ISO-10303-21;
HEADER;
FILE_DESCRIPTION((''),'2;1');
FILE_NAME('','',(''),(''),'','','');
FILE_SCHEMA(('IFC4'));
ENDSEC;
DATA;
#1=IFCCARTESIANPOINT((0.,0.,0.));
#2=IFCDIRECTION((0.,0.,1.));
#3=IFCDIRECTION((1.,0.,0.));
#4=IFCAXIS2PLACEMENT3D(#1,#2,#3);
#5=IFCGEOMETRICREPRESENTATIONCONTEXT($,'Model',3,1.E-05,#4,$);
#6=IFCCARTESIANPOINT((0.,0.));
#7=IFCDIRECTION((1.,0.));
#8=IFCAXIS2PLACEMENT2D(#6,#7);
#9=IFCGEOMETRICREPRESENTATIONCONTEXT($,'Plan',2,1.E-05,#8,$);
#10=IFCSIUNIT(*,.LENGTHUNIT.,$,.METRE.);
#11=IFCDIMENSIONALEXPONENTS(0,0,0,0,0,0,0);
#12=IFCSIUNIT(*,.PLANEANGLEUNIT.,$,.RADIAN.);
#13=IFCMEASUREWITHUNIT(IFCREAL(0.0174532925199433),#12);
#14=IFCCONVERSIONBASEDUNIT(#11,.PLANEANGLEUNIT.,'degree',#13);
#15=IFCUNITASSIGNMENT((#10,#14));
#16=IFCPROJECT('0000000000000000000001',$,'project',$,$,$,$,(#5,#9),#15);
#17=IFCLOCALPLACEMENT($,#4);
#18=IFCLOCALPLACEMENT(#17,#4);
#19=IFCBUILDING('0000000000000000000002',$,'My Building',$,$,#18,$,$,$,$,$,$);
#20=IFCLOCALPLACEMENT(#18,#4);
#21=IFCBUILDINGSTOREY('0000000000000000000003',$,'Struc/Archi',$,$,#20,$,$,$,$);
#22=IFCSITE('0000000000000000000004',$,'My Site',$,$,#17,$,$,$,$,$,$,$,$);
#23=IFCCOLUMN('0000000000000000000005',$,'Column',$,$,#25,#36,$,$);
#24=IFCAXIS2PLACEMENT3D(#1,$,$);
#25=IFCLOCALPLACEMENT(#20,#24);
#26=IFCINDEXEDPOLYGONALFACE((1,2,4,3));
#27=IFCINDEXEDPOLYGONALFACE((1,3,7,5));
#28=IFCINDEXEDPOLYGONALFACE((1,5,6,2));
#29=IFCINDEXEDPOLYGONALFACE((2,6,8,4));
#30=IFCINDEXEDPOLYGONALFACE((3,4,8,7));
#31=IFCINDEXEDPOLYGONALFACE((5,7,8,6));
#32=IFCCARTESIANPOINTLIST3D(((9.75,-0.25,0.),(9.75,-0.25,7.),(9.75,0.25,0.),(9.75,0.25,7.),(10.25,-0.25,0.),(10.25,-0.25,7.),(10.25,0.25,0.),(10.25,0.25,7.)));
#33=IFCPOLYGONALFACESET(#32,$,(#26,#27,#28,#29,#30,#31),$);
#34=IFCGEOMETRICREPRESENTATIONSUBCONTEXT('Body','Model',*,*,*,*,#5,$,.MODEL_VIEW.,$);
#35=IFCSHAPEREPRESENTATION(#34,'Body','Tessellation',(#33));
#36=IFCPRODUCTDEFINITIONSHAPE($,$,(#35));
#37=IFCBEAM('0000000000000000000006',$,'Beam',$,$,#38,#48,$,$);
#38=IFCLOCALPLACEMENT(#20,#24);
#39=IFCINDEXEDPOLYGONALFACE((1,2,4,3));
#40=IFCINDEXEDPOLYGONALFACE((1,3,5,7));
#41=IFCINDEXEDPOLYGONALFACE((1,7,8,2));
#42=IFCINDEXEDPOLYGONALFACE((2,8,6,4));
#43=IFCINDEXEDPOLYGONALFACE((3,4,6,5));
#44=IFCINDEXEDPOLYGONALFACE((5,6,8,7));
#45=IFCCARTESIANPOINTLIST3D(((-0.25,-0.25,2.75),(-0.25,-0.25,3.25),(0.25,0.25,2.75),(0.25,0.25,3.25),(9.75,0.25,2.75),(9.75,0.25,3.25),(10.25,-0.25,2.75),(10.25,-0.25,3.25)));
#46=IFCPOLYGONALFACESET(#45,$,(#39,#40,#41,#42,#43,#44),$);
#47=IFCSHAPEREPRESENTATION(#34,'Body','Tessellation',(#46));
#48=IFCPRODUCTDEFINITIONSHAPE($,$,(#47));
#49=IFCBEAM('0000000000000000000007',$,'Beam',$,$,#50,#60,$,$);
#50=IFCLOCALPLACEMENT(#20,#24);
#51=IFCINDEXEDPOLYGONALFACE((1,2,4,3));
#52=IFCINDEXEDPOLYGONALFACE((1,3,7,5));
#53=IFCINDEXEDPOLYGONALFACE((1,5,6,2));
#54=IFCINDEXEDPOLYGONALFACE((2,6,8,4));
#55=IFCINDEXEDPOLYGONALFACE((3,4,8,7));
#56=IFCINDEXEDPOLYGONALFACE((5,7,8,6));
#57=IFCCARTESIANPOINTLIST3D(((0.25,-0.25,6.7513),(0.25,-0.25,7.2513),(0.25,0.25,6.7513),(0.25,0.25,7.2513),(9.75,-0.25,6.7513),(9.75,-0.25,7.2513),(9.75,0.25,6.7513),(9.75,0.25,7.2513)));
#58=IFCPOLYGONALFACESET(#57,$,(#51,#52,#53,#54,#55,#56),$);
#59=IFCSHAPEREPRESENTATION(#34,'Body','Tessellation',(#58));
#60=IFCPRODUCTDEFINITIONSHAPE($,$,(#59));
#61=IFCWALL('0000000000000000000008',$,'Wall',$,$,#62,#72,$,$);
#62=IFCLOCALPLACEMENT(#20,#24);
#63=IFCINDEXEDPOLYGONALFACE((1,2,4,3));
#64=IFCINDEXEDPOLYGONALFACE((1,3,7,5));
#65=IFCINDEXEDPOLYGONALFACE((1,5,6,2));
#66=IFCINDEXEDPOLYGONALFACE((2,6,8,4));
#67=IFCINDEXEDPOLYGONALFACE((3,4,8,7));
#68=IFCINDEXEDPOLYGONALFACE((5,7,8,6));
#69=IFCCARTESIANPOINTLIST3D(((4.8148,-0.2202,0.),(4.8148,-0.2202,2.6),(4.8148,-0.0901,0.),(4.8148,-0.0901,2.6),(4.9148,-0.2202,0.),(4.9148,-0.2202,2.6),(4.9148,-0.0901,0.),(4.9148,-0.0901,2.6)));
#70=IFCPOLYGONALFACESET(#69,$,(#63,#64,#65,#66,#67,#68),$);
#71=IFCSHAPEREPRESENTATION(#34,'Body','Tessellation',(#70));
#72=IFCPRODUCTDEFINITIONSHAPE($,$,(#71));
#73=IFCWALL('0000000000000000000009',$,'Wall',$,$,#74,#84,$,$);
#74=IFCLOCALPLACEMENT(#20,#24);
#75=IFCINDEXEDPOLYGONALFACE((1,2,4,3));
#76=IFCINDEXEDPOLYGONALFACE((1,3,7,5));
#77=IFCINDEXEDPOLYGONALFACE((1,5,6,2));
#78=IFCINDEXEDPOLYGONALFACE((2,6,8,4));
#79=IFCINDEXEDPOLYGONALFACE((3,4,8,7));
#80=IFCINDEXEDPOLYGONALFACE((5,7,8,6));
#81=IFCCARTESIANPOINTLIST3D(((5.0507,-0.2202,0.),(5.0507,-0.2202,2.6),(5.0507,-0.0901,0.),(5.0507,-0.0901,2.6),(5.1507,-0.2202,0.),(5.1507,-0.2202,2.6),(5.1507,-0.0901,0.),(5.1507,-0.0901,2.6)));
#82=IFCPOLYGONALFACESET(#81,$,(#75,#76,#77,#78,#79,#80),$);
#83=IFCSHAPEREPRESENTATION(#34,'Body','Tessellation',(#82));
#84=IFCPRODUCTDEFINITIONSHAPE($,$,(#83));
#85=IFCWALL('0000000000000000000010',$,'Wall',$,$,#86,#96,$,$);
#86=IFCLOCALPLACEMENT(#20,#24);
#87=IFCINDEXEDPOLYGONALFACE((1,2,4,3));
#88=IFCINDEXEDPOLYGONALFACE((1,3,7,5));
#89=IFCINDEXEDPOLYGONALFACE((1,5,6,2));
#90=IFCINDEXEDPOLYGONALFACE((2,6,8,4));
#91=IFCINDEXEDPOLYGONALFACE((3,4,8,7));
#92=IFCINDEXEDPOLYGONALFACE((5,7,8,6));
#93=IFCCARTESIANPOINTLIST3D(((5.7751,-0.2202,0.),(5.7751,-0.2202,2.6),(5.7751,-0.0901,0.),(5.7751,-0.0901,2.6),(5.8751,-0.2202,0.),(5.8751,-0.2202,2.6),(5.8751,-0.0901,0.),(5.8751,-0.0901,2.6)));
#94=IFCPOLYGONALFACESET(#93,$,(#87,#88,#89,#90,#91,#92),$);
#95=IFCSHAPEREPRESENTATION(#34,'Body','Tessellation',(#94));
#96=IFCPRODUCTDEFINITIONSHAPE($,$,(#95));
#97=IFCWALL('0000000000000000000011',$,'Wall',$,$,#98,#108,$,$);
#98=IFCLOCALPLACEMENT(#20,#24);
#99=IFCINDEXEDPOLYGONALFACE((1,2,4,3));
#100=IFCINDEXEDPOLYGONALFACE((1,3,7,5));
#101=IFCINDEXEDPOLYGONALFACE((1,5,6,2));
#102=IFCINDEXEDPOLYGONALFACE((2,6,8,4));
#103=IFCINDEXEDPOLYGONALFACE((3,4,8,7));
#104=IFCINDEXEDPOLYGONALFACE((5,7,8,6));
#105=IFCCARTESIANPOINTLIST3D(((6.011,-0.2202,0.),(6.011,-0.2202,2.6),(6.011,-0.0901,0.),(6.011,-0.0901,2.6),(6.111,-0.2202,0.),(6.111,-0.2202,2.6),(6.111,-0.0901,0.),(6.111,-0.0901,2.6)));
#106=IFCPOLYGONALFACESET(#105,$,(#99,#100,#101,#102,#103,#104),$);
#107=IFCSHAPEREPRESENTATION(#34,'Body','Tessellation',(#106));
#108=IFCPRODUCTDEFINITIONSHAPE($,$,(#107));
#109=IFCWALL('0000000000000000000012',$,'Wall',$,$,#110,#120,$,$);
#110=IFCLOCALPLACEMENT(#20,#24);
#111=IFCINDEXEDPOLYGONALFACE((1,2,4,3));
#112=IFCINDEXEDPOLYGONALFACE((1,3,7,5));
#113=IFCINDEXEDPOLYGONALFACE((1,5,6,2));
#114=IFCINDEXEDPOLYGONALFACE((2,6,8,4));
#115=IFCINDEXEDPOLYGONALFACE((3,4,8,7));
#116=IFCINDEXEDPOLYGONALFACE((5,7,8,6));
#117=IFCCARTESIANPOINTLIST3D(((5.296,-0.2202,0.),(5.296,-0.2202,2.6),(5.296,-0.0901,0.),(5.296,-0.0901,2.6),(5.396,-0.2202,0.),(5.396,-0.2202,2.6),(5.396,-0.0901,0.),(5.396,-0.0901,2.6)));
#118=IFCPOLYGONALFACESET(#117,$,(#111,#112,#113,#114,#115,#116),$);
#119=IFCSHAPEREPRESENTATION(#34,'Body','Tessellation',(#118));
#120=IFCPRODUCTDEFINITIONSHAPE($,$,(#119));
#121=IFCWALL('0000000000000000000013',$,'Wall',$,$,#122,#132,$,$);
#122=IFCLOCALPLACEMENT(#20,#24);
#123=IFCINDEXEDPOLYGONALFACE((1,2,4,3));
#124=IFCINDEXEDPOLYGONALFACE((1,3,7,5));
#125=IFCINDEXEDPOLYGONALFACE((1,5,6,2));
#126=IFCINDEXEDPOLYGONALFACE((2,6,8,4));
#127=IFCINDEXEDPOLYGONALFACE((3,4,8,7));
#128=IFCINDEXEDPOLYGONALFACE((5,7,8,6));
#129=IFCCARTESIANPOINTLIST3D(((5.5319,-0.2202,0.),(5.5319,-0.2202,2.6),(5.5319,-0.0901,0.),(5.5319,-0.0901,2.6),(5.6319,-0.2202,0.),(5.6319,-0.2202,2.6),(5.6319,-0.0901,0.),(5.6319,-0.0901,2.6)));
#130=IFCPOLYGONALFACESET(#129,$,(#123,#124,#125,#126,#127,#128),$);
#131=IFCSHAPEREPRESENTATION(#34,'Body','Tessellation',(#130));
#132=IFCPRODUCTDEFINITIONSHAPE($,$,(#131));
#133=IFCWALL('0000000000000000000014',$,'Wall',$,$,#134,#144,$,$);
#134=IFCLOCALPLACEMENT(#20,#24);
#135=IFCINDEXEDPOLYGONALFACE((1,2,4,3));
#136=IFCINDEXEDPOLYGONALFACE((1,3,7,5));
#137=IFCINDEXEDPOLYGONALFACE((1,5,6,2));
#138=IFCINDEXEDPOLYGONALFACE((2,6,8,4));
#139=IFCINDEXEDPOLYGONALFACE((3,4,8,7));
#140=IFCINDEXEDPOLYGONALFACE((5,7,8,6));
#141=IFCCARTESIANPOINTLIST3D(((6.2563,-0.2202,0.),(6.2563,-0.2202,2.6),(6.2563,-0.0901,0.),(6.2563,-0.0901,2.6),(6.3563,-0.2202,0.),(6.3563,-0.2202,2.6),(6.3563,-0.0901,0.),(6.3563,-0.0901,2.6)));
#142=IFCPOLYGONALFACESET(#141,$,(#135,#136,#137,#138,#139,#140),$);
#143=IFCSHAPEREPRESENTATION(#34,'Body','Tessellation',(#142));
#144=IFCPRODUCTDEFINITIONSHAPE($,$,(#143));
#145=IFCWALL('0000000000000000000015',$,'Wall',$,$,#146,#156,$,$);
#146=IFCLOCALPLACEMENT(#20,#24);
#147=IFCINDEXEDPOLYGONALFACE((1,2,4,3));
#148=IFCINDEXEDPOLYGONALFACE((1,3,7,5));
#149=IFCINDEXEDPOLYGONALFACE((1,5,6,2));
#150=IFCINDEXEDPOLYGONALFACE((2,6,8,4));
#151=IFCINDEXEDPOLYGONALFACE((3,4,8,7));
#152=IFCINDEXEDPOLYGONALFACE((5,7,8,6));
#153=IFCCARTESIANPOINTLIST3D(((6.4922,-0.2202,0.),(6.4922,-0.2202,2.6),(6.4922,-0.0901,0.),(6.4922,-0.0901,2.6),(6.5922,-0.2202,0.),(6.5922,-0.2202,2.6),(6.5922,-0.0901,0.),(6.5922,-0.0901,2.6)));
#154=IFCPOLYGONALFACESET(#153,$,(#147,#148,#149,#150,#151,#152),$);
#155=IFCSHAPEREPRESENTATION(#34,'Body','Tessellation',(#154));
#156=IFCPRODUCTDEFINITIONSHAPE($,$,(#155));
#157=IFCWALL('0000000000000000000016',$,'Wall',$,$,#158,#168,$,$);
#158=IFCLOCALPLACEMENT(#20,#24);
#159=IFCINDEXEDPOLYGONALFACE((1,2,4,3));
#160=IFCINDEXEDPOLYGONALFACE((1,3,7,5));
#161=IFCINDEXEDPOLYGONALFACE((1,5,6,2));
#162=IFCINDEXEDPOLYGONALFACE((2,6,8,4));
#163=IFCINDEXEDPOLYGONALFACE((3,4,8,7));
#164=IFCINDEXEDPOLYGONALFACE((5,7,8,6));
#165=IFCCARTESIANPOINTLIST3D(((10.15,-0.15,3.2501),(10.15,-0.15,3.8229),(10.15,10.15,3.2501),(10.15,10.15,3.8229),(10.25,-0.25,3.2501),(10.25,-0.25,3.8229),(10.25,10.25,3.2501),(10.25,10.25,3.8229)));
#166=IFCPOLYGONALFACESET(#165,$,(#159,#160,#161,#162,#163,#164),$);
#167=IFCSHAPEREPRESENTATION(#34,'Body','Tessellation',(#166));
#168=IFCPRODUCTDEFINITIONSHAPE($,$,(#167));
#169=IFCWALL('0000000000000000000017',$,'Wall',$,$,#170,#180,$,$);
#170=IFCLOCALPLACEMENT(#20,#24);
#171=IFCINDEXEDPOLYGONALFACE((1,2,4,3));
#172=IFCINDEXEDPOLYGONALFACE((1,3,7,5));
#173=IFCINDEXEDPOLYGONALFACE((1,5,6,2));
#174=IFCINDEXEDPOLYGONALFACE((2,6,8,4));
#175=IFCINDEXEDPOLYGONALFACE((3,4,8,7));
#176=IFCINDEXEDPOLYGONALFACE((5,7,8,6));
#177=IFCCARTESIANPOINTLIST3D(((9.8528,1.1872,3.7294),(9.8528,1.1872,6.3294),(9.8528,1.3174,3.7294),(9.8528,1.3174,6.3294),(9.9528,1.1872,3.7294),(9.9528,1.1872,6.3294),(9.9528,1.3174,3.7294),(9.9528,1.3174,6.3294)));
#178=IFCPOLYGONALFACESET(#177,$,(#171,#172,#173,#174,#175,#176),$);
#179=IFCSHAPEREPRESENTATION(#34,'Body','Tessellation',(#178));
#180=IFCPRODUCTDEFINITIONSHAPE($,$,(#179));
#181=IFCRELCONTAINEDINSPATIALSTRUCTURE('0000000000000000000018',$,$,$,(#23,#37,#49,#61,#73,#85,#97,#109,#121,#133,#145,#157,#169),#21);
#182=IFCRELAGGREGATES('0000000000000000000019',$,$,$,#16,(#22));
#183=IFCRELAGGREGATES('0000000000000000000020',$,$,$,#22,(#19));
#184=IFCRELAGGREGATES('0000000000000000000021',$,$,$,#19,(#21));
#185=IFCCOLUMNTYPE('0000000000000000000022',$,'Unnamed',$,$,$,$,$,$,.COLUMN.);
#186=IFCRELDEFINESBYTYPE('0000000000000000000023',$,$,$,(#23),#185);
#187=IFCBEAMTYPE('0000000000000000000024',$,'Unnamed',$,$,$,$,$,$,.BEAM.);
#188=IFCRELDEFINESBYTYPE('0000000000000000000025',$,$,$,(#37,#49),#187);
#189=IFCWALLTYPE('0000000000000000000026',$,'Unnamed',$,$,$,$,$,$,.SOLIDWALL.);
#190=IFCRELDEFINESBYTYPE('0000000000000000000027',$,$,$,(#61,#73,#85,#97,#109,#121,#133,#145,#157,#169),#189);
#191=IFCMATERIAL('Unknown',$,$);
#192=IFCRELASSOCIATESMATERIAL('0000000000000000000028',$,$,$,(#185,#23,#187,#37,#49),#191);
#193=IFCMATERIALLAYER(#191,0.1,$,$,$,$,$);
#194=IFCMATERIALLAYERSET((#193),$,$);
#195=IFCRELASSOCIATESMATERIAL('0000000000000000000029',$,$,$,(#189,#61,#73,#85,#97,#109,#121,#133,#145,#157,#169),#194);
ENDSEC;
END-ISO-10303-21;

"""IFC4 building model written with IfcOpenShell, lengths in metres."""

from ifc_helpers import new_model, entity, si_unit, converted_unit, frame, origin_with_axes, origin_2d_with_axis, place, context, subcontext, project, spatial, line, indexed_curve, rectangle, outline, extrude, clip, halfspace, material, layer, layer_set, layer_usage, material_profile, profile_set, profile_usage, type_object, element, save


model = new_model("IFC4")

# Units and contexts
model_context = context("Model", 3, precision=1e-05, world=origin_with_axes())
plan_context = context("Plan", 2, precision=1e-05, world=origin_2d_with_axis())
body_context_1 = subcontext(model_context, "Body", "Model", "MODEL_VIEW")
ifc_project = project(units=[si_unit("LENGTHUNIT", "METRE"), converted_unit("PLANEANGLEUNIT", "degree", entity("IfcReal", 0.0174532925199433), si_unit("PLANEANGLEUNIT", "RADIAN"), dimensions=[0, 0, 0, 0, 0, 0, 0])], contexts=[model_context, plan_context])

# Site, building, storey
site_placement = place(None, origin_with_axes())
site = spatial("IfcSite", under=ifc_project, at=site_placement, Name="My Site")
building_placement = place(site_placement, origin_with_axes())
building = spatial("IfcBuilding", under=site, at=building_placement, Name="My Building")
storey_placement = place(building_placement, origin_with_axes())
storey = spatial("IfcBuildingStorey", under=building, at=storey_placement, Name="Struc/Archi")

# Column
ifc_material = material(Name="Unknown")
ifc_material_profile_1 = material_profile(ifc_material, rectangle(XDim=0.5, YDim=0.5))
ifc_profile_set_1 = profile_set([ifc_material_profile_1])
ifc_profile_usage_1 = profile_usage(ifc_profile_set_1, cardinal=5)
column_type = type_object("IfcColumnType", Name="Unnamed", PredefinedType="COLUMN", material=ifc_profile_set_1)
column_placement = place(storey_placement, frame((10.0, 0.0, 0.0), z_axis=(0.0, 0.0, 1.0), x_axis=(1.0, 0.0, 0.0)))
element("IfcColumn", 1, at=column_placement, inside=storey, type_object=column_type, material=ifc_profile_usage_1, Name="Column", context=body_context_1, shape_type="SweptSolid", body=[
    extrude(rectangle(XDim=0.5, YDim=0.5), origin_with_axes(), (0.0, 0.0, 1.0), 7.0),
])

# Beams
ifc_material_profile_2 = material_profile(ifc_material, rectangle(XDim=0.5, YDim=0.5))
ifc_profile_set_2 = profile_set([ifc_material_profile_2])
ifc_profile_usage_2 = profile_usage(ifc_profile_set_2, cardinal=5)
beam_type = type_object("IfcBeamType", Name="Unnamed", PredefinedType="BEAM", material=ifc_profile_set_2)
beam_1_placement = place(storey_placement, frame((10.25, 0.0, 3.0), z_axis=(-1.0, 0.0, 0.0), x_axis=(0.0, -1.0, 0.0)))
element("IfcBeam", 2, at=beam_1_placement, inside=storey, type_object=beam_type, material=ifc_profile_usage_2, Name="Beam", context=body_context_1, shape_type="Clipping", body=[
    clip(clip(extrude(rectangle(XDim=0.5, YDim=0.5), origin_with_axes(), (0.0, 0.0, 1.0), 10.5), halfspace(frame((0.25, -3.0, 10.5), z_axis=(-0.707107, 0.0, 0.707107), x_axis=(0.0, 1.0, 0.0)), False)), halfspace(frame((0.25, -3.0, 0.0), z_axis=(-0.707107, 0.0, -0.707107), x_axis=(0.0, 1.0, 0.0)), False)),
])
ifc_profile_usage_3 = profile_usage(ifc_profile_set_2, cardinal=5)
beam_2_placement = place(storey_placement, frame((9.75, 0.0, 7.0013), z_axis=(-1.0, 0.0, 0.0), x_axis=(0.0, -1.0, 0.0)))
element("IfcBeam", 3, at=beam_2_placement, inside=storey, type_object=beam_type, material=ifc_profile_usage_3, Name="Beam", context=body_context_1, shape_type="SweptSolid", body=[
    extrude(rectangle(XDim=0.5, YDim=0.5), origin_with_axes(), (0.0, 0.0, 1.0), 9.5),
])

# Shared definitions
ifc_layer = layer(ifc_material, 0.1)
ifc_layer_set = layer_set([ifc_layer])
wall_type = type_object("IfcWallType", Name="Unnamed", PredefinedType="SOLIDWALL", material=ifc_layer_set)

# Walls
ifc_layer_usage_1 = layer_usage(ifc_layer_set, "AXIS2", "POSITIVE", 0.0)
wall_1_placement = place(storey_placement, frame((4.8148, -0.0901, 0.0), z_axis=(0.0, 0.0, 1.0), x_axis=(0.0, -1.0, 0.0)))
element("IfcWall", 4, at=wall_1_placement, inside=storey, type_object=wall_type, material=ifc_layer_usage_1, Name="Wall", context=body_context_1, shape_type="SweptSolid", body=[
    extrude(outline(indexed_curve([(0.0, 0.0), (0.0, 0.1), (0.1301, 0.1), (0.1301, 0.0)], segments=[line(1, 2, 3, 4, 1)])), origin_with_axes(), (0.0, 0.0, 1.0), 2.6),
])
ifc_layer_usage_2 = layer_usage(ifc_layer_set, "AXIS2", "POSITIVE", 0.0)
wall_2_placement = place(storey_placement, frame((5.0507, -0.0901, 0.0), z_axis=(0.0, 0.0, 1.0), x_axis=(0.0, -1.0, 0.0)))
element("IfcWall", 5, at=wall_2_placement, inside=storey, type_object=wall_type, material=ifc_layer_usage_2, Name="Wall", context=body_context_1, shape_type="SweptSolid", body=[
    extrude(outline(indexed_curve([(0.0, 0.0), (0.0, 0.1), (0.1301, 0.1), (0.1301, 0.0)], segments=[line(1, 2, 3, 4, 1)])), origin_with_axes(), (0.0, 0.0, 1.0), 2.6),
])
ifc_layer_usage_3 = layer_usage(ifc_layer_set, "AXIS2", "POSITIVE", 0.0)
wall_3_placement = place(storey_placement, frame((5.7751, -0.0901, 0.0), z_axis=(0.0, 0.0, 1.0), x_axis=(0.0, -1.0, 0.0)))
element("IfcWall", 6, at=wall_3_placement, inside=storey, type_object=wall_type, material=ifc_layer_usage_3, Name="Wall", context=body_context_1, shape_type="SweptSolid", body=[
    extrude(outline(indexed_curve([(0.0, 0.0), (0.0, 0.1), (0.1301, 0.1), (0.1301, 0.0)], segments=[line(1, 2, 3, 4, 1)])), origin_with_axes(), (0.0, 0.0, 1.0), 2.6),
])
ifc_layer_usage_4 = layer_usage(ifc_layer_set, "AXIS2", "POSITIVE", 0.0)
wall_4_placement = place(storey_placement, frame((6.011, -0.0901, 0.0), z_axis=(0.0, 0.0, 1.0), x_axis=(0.0, -1.0, 0.0)))
element("IfcWall", 7, at=wall_4_placement, inside=storey, type_object=wall_type, material=ifc_layer_usage_4, Name="Wall", context=body_context_1, shape_type="SweptSolid", body=[
    extrude(outline(indexed_curve([(0.0, 0.0), (0.0, 0.1), (0.1301, 0.1), (0.1301, 0.0)], segments=[line(1, 2, 3, 4, 1)])), origin_with_axes(), (0.0, 0.0, 1.0), 2.6),
])
ifc_layer_usage_5 = layer_usage(ifc_layer_set, "AXIS2", "POSITIVE", 0.0)
wall_5_placement = place(storey_placement, frame((5.296, -0.0901, 0.0), z_axis=(0.0, 0.0, 1.0), x_axis=(0.0, -1.0, 0.0)))
element("IfcWall", 8, at=wall_5_placement, inside=storey, type_object=wall_type, material=ifc_layer_usage_5, Name="Wall", context=body_context_1, shape_type="SweptSolid", body=[
    extrude(outline(indexed_curve([(0.0, 0.0), (0.0, 0.1), (0.1301, 0.1), (0.1301, 0.0)], segments=[line(1, 2, 3, 4, 1)])), origin_with_axes(), (0.0, 0.0, 1.0), 2.6),
])
ifc_layer_usage_6 = layer_usage(ifc_layer_set, "AXIS2", "POSITIVE", 0.0)
wall_6_placement = place(storey_placement, frame((5.5319, -0.0901, 0.0), z_axis=(0.0, 0.0, 1.0), x_axis=(0.0, -1.0, 0.0)))
element("IfcWall", 9, at=wall_6_placement, inside=storey, type_object=wall_type, material=ifc_layer_usage_6, Name="Wall", context=body_context_1, shape_type="SweptSolid", body=[
    extrude(outline(indexed_curve([(0.0, 0.0), (0.0, 0.1), (0.1301, 0.1), (0.1301, 0.0)], segments=[line(1, 2, 3, 4, 1)])), origin_with_axes(), (0.0, 0.0, 1.0), 2.6),
])
ifc_layer_usage_7 = layer_usage(ifc_layer_set, "AXIS2", "POSITIVE", 0.0)
wall_7_placement = place(storey_placement, frame((6.2563, -0.0901, 0.0), z_axis=(0.0, 0.0, 1.0), x_axis=(0.0, -1.0, 0.0)))
element("IfcWall", 10, at=wall_7_placement, inside=storey, type_object=wall_type, material=ifc_layer_usage_7, Name="Wall", context=body_context_1, shape_type="SweptSolid", body=[
    extrude(outline(indexed_curve([(0.0, 0.0), (0.0, 0.1), (0.1301, 0.1), (0.1301, 0.0)], segments=[line(1, 2, 3, 4, 1)])), origin_with_axes(), (0.0, 0.0, 1.0), 2.6),
])
ifc_layer_usage_8 = layer_usage(ifc_layer_set, "AXIS2", "POSITIVE", 0.0)
wall_8_placement = place(storey_placement, frame((6.4922, -0.0901, 0.0), z_axis=(0.0, 0.0, 1.0), x_axis=(0.0, -1.0, 0.0)))
element("IfcWall", 11, at=wall_8_placement, inside=storey, type_object=wall_type, material=ifc_layer_usage_8, Name="Wall", context=body_context_1, shape_type="SweptSolid", body=[
    extrude(outline(indexed_curve([(0.0, 0.0), (0.0, 0.1), (0.1301, 0.1), (0.1301, 0.0)], segments=[line(1, 2, 3, 4, 1)])), origin_with_axes(), (0.0, 0.0, 1.0), 2.6),
])
ifc_layer_usage_9 = layer_usage(ifc_layer_set, "AXIS2", "POSITIVE", 0.0)
wall_9_placement = place(storey_placement, frame((10.25, -0.25, 3.2501), z_axis=(0.0, 0.0, 1.0), x_axis=(0.0, 1.0, 0.0)))
element("IfcWall", 12, at=wall_9_placement, inside=storey, type_object=wall_type, material=ifc_layer_usage_9, Name="Wall", context=body_context_1, shape_type="SweptSolid", body=[
    extrude(outline(indexed_curve([(0.0, 0.0), (0.1, 0.1), (10.4, 0.1), (10.5, 0.0)], segments=[line(1, 2, 3, 4, 1)])), origin_with_axes(), (0.0, 0.0, 1.0), 0.5728),
])
ifc_layer_usage_10 = layer_usage(ifc_layer_set, "AXIS2", "POSITIVE", 0.0)
wall_10_placement = place(storey_placement, frame((9.8528, 1.3174, 3.7294), z_axis=(0.0, 0.0, 1.0), x_axis=(0.0, -1.0, 0.0)))
element("IfcWall", 13, at=wall_10_placement, inside=storey, type_object=wall_type, material=ifc_layer_usage_10, Name="Wall", context=body_context_1, shape_type="SweptSolid", body=[
    extrude(outline(indexed_curve([(0.0, 0.0), (0.0, 0.1), (0.1301, 0.1), (0.1301, 0.0)], segments=[line(1, 2, 3, 4, 1)])), origin_with_axes(), (0.0, 0.0, 1.0), 2.6),
])

save(model, "model.ifc")
